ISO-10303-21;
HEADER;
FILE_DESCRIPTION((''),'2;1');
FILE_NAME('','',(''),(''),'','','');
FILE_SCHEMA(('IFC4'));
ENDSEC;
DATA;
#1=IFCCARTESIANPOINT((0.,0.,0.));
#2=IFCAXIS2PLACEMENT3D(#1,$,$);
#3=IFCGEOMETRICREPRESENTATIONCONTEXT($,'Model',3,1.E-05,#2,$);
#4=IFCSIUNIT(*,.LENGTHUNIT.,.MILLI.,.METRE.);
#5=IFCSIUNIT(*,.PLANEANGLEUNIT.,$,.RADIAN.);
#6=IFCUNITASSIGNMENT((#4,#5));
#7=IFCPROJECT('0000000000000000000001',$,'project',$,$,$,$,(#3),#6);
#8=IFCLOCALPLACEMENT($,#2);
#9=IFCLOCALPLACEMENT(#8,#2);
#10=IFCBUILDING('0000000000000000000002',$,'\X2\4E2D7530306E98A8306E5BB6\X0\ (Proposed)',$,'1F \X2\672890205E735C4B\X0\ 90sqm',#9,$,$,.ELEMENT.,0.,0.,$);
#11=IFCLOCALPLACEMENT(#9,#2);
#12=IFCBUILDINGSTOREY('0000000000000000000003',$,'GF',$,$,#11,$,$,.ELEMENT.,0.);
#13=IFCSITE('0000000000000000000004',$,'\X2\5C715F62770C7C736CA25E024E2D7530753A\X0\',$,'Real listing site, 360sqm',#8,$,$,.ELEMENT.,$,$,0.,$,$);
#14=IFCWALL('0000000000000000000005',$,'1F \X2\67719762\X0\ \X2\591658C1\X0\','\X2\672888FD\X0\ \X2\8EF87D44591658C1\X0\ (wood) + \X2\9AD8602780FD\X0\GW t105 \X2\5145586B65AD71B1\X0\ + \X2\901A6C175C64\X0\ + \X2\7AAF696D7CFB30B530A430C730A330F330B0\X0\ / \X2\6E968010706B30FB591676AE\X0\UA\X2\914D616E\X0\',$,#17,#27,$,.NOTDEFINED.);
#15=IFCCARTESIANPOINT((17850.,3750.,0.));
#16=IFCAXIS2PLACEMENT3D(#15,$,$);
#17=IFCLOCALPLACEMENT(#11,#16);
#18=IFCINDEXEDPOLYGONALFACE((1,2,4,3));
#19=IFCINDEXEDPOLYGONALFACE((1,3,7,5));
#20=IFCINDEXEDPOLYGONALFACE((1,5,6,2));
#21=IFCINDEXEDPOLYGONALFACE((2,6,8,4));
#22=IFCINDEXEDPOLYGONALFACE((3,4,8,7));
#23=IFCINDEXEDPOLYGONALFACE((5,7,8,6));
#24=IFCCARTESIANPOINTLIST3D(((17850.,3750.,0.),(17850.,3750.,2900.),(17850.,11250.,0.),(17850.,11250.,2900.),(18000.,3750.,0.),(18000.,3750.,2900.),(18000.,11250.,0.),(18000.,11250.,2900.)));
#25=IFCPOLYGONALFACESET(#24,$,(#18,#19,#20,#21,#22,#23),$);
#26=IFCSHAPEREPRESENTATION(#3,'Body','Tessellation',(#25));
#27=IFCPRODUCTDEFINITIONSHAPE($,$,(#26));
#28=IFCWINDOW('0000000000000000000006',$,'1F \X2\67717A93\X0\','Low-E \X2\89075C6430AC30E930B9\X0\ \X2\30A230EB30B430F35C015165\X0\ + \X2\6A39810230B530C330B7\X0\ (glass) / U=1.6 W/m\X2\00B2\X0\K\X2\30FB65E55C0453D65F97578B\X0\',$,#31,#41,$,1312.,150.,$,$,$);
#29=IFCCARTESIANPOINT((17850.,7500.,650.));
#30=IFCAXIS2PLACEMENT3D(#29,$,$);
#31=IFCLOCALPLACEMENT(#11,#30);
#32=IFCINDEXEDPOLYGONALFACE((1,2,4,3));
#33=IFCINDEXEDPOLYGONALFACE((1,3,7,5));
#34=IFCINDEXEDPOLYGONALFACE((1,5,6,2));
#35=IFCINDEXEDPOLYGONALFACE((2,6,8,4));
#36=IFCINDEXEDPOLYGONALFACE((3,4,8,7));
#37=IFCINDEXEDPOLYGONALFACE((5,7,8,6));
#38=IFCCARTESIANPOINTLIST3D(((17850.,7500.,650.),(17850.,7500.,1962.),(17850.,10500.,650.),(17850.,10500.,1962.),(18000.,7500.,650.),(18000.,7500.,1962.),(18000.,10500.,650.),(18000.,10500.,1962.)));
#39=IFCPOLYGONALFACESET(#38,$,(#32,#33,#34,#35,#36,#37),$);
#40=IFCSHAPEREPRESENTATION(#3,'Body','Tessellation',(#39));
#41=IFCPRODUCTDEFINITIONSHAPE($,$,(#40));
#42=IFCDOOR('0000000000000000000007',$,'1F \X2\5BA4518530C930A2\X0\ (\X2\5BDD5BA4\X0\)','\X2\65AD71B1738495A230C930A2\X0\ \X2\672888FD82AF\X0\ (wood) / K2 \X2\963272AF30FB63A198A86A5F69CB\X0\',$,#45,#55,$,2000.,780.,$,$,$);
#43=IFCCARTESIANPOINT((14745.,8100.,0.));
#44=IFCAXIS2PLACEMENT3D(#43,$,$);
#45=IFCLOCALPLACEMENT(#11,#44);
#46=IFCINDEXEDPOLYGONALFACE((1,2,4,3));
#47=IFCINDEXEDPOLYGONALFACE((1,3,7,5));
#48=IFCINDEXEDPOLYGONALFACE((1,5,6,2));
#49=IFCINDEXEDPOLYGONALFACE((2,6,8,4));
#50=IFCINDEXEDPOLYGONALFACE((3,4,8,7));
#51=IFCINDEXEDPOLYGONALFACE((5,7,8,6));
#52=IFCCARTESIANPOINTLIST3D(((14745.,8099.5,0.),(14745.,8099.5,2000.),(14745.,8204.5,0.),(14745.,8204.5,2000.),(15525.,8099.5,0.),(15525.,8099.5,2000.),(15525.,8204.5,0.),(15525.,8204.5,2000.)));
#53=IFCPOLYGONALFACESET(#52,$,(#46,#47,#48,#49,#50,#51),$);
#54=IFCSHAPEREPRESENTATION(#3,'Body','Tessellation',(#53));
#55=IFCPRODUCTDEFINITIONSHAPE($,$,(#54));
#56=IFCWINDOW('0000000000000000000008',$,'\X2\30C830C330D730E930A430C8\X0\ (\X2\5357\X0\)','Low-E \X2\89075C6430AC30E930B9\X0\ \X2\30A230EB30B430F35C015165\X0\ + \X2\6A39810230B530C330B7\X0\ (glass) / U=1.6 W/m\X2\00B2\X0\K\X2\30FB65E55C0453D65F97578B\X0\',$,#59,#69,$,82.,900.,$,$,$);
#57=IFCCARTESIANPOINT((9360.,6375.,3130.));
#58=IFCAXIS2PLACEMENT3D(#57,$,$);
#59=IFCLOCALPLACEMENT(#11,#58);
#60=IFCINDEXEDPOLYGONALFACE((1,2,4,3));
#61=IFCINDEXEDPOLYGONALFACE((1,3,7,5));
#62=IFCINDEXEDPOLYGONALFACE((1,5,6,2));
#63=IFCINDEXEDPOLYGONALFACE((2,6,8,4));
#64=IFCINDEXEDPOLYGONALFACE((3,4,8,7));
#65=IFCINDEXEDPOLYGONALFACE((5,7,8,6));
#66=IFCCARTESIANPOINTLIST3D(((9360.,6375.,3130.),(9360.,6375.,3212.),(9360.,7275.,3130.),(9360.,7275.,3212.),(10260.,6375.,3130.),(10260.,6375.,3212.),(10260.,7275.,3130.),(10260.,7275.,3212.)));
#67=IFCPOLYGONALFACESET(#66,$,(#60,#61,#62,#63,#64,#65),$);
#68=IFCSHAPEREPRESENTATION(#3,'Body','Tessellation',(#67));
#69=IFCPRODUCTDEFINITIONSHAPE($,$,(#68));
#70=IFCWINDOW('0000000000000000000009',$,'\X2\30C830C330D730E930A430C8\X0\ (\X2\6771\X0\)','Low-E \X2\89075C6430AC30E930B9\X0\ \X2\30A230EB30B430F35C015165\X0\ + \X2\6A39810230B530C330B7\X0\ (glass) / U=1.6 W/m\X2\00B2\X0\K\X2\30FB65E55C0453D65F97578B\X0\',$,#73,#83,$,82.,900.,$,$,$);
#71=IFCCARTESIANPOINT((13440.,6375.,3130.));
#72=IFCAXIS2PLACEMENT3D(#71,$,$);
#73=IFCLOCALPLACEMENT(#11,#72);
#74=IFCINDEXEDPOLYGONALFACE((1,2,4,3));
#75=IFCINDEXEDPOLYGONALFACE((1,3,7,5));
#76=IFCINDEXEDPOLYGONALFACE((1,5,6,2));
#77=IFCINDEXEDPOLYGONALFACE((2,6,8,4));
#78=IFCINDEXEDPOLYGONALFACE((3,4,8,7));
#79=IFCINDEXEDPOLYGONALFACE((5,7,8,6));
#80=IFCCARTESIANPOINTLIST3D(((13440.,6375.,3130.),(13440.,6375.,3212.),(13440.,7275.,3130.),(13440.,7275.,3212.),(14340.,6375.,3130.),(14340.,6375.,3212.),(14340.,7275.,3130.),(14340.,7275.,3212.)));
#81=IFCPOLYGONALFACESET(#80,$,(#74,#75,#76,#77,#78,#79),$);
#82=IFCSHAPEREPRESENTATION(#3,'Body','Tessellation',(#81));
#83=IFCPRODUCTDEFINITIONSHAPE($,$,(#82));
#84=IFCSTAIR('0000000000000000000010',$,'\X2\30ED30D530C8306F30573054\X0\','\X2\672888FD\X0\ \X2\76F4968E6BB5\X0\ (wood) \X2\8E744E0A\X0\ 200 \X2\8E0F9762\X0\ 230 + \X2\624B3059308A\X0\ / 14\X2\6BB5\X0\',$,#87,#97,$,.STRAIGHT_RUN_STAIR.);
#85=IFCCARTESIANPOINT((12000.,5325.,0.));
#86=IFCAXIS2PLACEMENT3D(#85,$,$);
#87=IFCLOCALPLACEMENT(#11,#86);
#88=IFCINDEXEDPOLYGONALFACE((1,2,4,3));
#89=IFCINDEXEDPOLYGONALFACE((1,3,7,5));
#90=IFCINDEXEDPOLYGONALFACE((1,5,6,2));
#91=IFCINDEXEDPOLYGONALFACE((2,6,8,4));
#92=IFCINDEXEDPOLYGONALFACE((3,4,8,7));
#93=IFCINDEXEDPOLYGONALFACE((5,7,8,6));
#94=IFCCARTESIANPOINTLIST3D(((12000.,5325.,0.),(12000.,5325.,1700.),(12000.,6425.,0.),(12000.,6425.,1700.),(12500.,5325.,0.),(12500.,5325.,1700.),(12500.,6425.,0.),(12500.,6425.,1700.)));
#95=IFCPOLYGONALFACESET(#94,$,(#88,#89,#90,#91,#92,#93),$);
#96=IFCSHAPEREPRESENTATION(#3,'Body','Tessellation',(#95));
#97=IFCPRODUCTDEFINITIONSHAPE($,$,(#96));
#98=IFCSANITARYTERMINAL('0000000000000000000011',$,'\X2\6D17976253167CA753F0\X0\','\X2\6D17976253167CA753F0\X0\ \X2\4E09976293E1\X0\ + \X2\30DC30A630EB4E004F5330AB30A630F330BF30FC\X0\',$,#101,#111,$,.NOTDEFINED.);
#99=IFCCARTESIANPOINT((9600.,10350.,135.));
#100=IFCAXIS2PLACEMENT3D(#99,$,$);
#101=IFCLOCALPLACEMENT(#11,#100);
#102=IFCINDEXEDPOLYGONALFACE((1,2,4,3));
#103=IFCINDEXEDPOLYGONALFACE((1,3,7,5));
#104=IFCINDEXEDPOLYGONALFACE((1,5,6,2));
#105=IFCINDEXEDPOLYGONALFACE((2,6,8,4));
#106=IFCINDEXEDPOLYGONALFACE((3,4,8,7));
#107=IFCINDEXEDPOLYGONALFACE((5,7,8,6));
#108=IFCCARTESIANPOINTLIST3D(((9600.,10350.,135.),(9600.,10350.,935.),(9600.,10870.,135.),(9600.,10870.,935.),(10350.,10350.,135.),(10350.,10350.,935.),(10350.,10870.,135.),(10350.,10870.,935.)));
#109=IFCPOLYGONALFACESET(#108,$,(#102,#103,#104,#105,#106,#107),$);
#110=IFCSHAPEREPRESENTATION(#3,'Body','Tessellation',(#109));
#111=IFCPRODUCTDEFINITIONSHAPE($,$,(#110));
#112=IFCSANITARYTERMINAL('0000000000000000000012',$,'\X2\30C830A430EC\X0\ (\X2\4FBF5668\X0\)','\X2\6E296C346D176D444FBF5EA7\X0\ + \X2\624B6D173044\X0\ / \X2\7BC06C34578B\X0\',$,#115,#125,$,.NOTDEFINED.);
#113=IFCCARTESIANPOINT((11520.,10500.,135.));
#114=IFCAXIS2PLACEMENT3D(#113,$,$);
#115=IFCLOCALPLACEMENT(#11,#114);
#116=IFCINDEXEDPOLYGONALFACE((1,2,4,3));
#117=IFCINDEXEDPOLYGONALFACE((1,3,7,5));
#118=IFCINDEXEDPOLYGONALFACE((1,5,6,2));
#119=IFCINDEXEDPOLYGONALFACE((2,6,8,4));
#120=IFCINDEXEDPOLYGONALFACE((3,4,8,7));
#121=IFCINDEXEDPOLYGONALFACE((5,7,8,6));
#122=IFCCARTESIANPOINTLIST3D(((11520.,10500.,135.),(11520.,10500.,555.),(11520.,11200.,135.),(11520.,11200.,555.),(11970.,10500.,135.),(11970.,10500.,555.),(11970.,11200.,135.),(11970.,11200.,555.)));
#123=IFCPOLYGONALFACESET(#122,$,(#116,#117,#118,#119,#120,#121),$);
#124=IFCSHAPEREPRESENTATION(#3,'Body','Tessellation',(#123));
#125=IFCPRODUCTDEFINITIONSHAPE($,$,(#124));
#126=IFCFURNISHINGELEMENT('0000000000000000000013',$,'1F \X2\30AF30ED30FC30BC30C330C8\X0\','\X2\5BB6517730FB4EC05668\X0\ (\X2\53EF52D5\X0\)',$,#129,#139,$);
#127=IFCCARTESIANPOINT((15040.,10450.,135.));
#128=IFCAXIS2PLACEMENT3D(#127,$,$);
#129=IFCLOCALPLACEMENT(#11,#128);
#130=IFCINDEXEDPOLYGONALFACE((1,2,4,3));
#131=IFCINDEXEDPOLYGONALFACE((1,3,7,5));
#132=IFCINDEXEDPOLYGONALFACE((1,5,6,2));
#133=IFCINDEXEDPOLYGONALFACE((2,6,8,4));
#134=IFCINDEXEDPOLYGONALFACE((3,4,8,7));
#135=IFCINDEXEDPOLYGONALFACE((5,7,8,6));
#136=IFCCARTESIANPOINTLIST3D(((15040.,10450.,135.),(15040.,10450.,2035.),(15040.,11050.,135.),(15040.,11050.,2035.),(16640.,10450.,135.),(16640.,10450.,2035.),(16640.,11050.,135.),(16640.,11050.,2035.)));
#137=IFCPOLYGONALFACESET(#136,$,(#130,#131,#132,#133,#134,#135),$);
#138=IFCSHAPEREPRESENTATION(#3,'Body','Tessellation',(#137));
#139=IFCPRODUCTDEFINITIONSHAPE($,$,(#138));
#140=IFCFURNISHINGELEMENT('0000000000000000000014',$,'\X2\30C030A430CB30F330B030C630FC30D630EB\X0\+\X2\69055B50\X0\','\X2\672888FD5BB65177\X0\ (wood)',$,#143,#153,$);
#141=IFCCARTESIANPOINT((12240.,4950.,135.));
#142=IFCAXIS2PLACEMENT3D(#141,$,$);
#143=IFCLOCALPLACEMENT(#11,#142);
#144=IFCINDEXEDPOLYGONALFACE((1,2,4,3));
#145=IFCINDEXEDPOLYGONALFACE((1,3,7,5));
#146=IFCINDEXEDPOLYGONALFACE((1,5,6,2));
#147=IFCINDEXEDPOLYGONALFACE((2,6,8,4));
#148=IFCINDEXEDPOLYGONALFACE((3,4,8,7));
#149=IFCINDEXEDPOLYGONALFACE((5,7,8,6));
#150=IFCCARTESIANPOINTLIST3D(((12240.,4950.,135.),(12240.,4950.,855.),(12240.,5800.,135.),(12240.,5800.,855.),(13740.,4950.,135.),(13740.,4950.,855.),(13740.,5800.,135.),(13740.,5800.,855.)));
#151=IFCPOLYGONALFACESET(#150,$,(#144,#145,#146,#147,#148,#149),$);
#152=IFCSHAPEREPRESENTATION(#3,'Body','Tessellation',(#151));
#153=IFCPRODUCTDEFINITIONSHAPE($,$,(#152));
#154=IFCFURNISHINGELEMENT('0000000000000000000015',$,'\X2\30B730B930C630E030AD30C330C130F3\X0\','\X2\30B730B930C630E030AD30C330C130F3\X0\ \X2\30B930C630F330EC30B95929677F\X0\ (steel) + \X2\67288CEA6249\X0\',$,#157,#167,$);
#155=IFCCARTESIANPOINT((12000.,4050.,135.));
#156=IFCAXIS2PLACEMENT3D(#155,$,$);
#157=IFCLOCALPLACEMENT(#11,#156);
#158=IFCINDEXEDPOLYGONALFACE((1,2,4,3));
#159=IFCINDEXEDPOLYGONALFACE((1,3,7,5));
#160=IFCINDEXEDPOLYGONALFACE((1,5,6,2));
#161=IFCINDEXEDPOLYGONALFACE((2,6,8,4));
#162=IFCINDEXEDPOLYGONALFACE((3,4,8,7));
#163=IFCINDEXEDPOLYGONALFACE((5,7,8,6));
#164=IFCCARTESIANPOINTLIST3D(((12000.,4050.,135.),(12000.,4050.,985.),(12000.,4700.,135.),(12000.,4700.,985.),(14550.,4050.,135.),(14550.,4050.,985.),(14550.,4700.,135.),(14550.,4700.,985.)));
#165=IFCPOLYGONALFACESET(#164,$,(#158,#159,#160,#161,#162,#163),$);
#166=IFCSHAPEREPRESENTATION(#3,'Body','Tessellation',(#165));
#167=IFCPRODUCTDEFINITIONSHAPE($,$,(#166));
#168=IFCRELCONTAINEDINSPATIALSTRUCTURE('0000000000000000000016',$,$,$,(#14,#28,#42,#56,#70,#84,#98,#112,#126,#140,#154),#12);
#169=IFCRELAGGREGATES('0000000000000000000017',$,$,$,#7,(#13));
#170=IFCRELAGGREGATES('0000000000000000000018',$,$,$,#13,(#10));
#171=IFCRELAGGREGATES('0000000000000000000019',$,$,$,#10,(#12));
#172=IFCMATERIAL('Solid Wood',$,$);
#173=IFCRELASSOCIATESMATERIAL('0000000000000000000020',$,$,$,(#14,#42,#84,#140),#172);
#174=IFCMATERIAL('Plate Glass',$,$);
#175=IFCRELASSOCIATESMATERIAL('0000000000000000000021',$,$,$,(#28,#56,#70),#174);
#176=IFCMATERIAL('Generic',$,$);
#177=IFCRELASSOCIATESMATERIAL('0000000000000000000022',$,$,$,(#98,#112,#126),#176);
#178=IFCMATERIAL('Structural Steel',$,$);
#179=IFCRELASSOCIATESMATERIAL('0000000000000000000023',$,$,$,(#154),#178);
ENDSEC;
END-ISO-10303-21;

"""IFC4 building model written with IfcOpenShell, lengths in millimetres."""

from ifc_helpers import new_model, si_unit, frame, frame_2d, origin, place, context, project, spatial, rectangle, extrude, material, element, fill, save


model = new_model("IFC4")

# Units and contexts
model_context = context("Model", 3, precision=1e-05, world=origin())
ifc_project = project(units=[si_unit("LENGTHUNIT", "METRE", prefix="MILLI"), si_unit("PLANEANGLEUNIT", "RADIAN")], contexts=[model_context])

# Site, building, storey
site_placement = place(None, origin())
site = spatial("IfcSite", under=ifc_project, at=site_placement, Name="山形県米沢市中田町", ObjectType="Real listing site, 360sqm", CompositionType="ELEMENT", RefElevation=0.0)
building_placement = place(site_placement, origin())
building = spatial("IfcBuilding", under=site, at=building_placement, Name="中田の風の家 (Proposed)", ObjectType="1F 木造平屋 90sqm", CompositionType="ELEMENT", ElevationOfRefHeight=0.0, ElevationOfTerrain=0.0)
storey_placement = place(building_placement, origin())
storey = spatial("IfcBuildingStorey", under=building, at=storey_placement, Name="GF", CompositionType="ELEMENT", Elevation=0.0)

# Wall, opening, window
ifc_material_1 = material(Name="Solid Wood")
wall_1_placement = place(storey_placement, frame((17850.0, 3750.0, 0.0)))
wall_1 = element("IfcWall", 1, at=wall_1_placement, inside=storey, material=ifc_material_1, Name="1F 東面 外壁", Description="木製 軸組外壁 (wood) + 高性能GW t105 充填断熱 + 通気層 + 窯業系サイディング / 準耐火・外皮UA配慮", PredefinedType="NOTDEFINED", context=model_context, shape_type="SweptSolid", body=[
    extrude(rectangle(XDim=150.0, YDim=7500.0, at=frame_2d((75.0, 3750.0))), frame((17850.0, 3750.0, 0.0)), (0.0, 0.0, 1.0), 2900.0),
])
opening_placement = place(storey_placement, frame((17850.0, 7500.0, 650.0)))
opening = element("IfcOpeningElement", 2, at=opening_placement, cuts=wall_1, PredefinedType="NOTDEFINED", context=model_context, shape_type="SweptSolid", body=[
    extrude(rectangle(XDim=150.0, YDim=3000.0, at=frame_2d((75.0, 1500.0))), frame((17850.0, 7500.0, 650.0)), (0.0, 0.0, 1.0), 1312.0),
])
ifc_material_2 = material(Name="Plate Glass")
window_1_placement = place(storey_placement, frame((17850.0, 7500.0, 650.0)))
window_1 = element("IfcWindow", 3, at=window_1_placement, inside=storey, material=ifc_material_2, Name="1F 東窓", Description="Low-E 複層ガラス アルゴン封入 + 樹脂サッシ (glass) / U=1.6 W/m²K・日射取得型", OverallHeight=1312.0, OverallWidth=150.0, context=model_context, shape_type="SweptSolid", body=[
    extrude(rectangle(XDim=150.0, YDim=3000.0, at=frame_2d((75.0, 1500.0))), frame((17850.0, 7500.0, 650.0)), (0.0, 0.0, 1.0), 1312.0),
])
fill(opening, window_1)

# Door
door_placement = place(storey_placement, frame((14745.0, 8100.0, 0.0)))
element("IfcDoor", 4, at=door_placement, inside=storey, material=ifc_material_1, Name="1F 室内ドア (寝室)", Description="断熱玄関ドア 木製芯 (wood) / K2 防犯・採風機構", OverallHeight=2000.0, OverallWidth=780.0, context=model_context, shape_type="SweptSolid", body=[
    extrude(rectangle(XDim=780.0, YDim=105.0, at=frame_2d((390.0, 52.0))), frame((14745.0, 8100.0, 0.0)), (0.0, 0.0, 1.0), 2000.0),
])

# Windows
window_2_placement = place(storey_placement, frame((9360.0, 6375.0, 3130.0)))
element("IfcWindow", 5, at=window_2_placement, inside=storey, material=ifc_material_2, Name="トップライト (南)", Description="Low-E 複層ガラス アルゴン封入 + 樹脂サッシ (glass) / U=1.6 W/m²K・日射取得型", OverallHeight=82.0, OverallWidth=900.0, context=model_context, shape_type="SweptSolid", body=[
    extrude(rectangle(XDim=900.0, YDim=900.0, at=frame_2d((450.0, 450.0))), frame((9360.0, 6375.0, 3130.0)), (0.0, 0.0, 1.0), 82.0),
])
window_3_placement = place(storey_placement, frame((13440.0, 6375.0, 3130.0)))
element("IfcWindow", 6, at=window_3_placement, inside=storey, material=ifc_material_2, Name="トップライト (東)", Description="Low-E 複層ガラス アルゴン封入 + 樹脂サッシ (glass) / U=1.6 W/m²K・日射取得型", OverallHeight=82.0, OverallWidth=900.0, context=model_context, shape_type="SweptSolid", body=[
    extrude(rectangle(XDim=900.0, YDim=900.0, at=frame_2d((450.0, 450.0))), frame((13440.0, 6375.0, 3130.0)), (0.0, 0.0, 1.0), 82.0),
])

# Stair
stair_placement = place(storey_placement, frame((12000.0, 5325.0, 0.0)))
element("IfcStair", 7, at=stair_placement, inside=storey, material=ifc_material_1, Name="ロフトはしご", Description="木製 直階段 (wood) 蹴上 200 踏面 230 + 手すり / 14段", PredefinedType="STRAIGHT_RUN_STAIR", context=model_context, shape_type="SweptSolid", body=[
    extrude(rectangle(XDim=500.0, YDim=1100.0, at=frame_2d((250.0, 550.0))), frame((12000.0, 5325.0, 0.0)), (0.0, 0.0, 1.0), 1700.0),
])

# Sanitary terminals
ifc_material_3 = material(Name="Generic")
sanitary_terminal_1_placement = place(storey_placement, frame((9600.0, 10350.0, 135.0)))
element("IfcSanitaryTerminal", 8, at=sanitary_terminal_1_placement, inside=storey, material=ifc_material_3, Name="洗面化粧台", Description="洗面化粧台 三面鏡 + ボウル一体カウンター", PredefinedType="NOTDEFINED", context=model_context, shape_type="SweptSolid", body=[
    extrude(rectangle(XDim=750.0, YDim=520.0, at=frame_2d((375.0, 260.0))), frame((9600.0, 10350.0, 135.0)), (0.0, 0.0, 1.0), 800.0),
])
sanitary_terminal_2_placement = place(storey_placement, frame((11520.0, 10500.0, 135.0)))
element("IfcSanitaryTerminal", 9, at=sanitary_terminal_2_placement, inside=storey, material=ifc_material_3, Name="トイレ (便器)", Description="温水洗浄便座 + 手洗い / 節水型", PredefinedType="NOTDEFINED", context=model_context, shape_type="SweptSolid", body=[
    extrude(rectangle(XDim=450.0, YDim=700.0, at=frame_2d((225.0, 350.0))), frame((11520.0, 10500.0, 135.0)), (0.0, 0.0, 1.0), 420.0),
])

# Furnishing elements
furnishing_1_placement = place(storey_placement, frame((15040.0, 10450.0, 135.0)))
element("IfcFurnishingElement", 10, at=furnishing_1_placement, inside=storey, material=ifc_material_3, Name="1F クローゼット", Description="家具・什器 (可動)", context=model_context, shape_type="SweptSolid", body=[
    extrude(rectangle(XDim=1600.0, YDim=600.0, at=frame_2d((800.0, 300.0))), frame((15040.0, 10450.0, 135.0)), (0.0, 0.0, 1.0), 1900.0),
])
furnishing_2_placement = place(storey_placement, frame((12240.0, 4950.0, 135.0)))
element("IfcFurnishingElement", 11, at=furnishing_2_placement, inside=storey, material=ifc_material_1, Name="ダイニングテーブル+椅子", Description="木製家具 (wood)", context=model_context, shape_type="SweptSolid", body=[
    extrude(rectangle(XDim=1500.0, YDim=850.0, at=frame_2d((750.0, 425.0))), frame((12240.0, 4950.0, 135.0)), (0.0, 0.0, 1.0), 720.0),
])
ifc_material_4 = material(Name="Structural Steel")
furnishing_3_placement = place(storey_placement, frame((12000.0, 4050.0, 135.0)))
element("IfcFurnishingElement", 12, at=furnishing_3_placement, inside=storey, material=ifc_material_4, Name="システムキッチン", Description="システムキッチン ステンレス天板 (steel) + 木質扉", context=model_context, shape_type="SweptSolid", body=[
    extrude(rectangle(XDim=2550.0, YDim=650.0, at=frame_2d((1275.0, 325.0))), frame((12000.0, 4050.0, 135.0)), (0.0, 0.0, 1.0), 850.0),
])

save(model, "model.ifc")
